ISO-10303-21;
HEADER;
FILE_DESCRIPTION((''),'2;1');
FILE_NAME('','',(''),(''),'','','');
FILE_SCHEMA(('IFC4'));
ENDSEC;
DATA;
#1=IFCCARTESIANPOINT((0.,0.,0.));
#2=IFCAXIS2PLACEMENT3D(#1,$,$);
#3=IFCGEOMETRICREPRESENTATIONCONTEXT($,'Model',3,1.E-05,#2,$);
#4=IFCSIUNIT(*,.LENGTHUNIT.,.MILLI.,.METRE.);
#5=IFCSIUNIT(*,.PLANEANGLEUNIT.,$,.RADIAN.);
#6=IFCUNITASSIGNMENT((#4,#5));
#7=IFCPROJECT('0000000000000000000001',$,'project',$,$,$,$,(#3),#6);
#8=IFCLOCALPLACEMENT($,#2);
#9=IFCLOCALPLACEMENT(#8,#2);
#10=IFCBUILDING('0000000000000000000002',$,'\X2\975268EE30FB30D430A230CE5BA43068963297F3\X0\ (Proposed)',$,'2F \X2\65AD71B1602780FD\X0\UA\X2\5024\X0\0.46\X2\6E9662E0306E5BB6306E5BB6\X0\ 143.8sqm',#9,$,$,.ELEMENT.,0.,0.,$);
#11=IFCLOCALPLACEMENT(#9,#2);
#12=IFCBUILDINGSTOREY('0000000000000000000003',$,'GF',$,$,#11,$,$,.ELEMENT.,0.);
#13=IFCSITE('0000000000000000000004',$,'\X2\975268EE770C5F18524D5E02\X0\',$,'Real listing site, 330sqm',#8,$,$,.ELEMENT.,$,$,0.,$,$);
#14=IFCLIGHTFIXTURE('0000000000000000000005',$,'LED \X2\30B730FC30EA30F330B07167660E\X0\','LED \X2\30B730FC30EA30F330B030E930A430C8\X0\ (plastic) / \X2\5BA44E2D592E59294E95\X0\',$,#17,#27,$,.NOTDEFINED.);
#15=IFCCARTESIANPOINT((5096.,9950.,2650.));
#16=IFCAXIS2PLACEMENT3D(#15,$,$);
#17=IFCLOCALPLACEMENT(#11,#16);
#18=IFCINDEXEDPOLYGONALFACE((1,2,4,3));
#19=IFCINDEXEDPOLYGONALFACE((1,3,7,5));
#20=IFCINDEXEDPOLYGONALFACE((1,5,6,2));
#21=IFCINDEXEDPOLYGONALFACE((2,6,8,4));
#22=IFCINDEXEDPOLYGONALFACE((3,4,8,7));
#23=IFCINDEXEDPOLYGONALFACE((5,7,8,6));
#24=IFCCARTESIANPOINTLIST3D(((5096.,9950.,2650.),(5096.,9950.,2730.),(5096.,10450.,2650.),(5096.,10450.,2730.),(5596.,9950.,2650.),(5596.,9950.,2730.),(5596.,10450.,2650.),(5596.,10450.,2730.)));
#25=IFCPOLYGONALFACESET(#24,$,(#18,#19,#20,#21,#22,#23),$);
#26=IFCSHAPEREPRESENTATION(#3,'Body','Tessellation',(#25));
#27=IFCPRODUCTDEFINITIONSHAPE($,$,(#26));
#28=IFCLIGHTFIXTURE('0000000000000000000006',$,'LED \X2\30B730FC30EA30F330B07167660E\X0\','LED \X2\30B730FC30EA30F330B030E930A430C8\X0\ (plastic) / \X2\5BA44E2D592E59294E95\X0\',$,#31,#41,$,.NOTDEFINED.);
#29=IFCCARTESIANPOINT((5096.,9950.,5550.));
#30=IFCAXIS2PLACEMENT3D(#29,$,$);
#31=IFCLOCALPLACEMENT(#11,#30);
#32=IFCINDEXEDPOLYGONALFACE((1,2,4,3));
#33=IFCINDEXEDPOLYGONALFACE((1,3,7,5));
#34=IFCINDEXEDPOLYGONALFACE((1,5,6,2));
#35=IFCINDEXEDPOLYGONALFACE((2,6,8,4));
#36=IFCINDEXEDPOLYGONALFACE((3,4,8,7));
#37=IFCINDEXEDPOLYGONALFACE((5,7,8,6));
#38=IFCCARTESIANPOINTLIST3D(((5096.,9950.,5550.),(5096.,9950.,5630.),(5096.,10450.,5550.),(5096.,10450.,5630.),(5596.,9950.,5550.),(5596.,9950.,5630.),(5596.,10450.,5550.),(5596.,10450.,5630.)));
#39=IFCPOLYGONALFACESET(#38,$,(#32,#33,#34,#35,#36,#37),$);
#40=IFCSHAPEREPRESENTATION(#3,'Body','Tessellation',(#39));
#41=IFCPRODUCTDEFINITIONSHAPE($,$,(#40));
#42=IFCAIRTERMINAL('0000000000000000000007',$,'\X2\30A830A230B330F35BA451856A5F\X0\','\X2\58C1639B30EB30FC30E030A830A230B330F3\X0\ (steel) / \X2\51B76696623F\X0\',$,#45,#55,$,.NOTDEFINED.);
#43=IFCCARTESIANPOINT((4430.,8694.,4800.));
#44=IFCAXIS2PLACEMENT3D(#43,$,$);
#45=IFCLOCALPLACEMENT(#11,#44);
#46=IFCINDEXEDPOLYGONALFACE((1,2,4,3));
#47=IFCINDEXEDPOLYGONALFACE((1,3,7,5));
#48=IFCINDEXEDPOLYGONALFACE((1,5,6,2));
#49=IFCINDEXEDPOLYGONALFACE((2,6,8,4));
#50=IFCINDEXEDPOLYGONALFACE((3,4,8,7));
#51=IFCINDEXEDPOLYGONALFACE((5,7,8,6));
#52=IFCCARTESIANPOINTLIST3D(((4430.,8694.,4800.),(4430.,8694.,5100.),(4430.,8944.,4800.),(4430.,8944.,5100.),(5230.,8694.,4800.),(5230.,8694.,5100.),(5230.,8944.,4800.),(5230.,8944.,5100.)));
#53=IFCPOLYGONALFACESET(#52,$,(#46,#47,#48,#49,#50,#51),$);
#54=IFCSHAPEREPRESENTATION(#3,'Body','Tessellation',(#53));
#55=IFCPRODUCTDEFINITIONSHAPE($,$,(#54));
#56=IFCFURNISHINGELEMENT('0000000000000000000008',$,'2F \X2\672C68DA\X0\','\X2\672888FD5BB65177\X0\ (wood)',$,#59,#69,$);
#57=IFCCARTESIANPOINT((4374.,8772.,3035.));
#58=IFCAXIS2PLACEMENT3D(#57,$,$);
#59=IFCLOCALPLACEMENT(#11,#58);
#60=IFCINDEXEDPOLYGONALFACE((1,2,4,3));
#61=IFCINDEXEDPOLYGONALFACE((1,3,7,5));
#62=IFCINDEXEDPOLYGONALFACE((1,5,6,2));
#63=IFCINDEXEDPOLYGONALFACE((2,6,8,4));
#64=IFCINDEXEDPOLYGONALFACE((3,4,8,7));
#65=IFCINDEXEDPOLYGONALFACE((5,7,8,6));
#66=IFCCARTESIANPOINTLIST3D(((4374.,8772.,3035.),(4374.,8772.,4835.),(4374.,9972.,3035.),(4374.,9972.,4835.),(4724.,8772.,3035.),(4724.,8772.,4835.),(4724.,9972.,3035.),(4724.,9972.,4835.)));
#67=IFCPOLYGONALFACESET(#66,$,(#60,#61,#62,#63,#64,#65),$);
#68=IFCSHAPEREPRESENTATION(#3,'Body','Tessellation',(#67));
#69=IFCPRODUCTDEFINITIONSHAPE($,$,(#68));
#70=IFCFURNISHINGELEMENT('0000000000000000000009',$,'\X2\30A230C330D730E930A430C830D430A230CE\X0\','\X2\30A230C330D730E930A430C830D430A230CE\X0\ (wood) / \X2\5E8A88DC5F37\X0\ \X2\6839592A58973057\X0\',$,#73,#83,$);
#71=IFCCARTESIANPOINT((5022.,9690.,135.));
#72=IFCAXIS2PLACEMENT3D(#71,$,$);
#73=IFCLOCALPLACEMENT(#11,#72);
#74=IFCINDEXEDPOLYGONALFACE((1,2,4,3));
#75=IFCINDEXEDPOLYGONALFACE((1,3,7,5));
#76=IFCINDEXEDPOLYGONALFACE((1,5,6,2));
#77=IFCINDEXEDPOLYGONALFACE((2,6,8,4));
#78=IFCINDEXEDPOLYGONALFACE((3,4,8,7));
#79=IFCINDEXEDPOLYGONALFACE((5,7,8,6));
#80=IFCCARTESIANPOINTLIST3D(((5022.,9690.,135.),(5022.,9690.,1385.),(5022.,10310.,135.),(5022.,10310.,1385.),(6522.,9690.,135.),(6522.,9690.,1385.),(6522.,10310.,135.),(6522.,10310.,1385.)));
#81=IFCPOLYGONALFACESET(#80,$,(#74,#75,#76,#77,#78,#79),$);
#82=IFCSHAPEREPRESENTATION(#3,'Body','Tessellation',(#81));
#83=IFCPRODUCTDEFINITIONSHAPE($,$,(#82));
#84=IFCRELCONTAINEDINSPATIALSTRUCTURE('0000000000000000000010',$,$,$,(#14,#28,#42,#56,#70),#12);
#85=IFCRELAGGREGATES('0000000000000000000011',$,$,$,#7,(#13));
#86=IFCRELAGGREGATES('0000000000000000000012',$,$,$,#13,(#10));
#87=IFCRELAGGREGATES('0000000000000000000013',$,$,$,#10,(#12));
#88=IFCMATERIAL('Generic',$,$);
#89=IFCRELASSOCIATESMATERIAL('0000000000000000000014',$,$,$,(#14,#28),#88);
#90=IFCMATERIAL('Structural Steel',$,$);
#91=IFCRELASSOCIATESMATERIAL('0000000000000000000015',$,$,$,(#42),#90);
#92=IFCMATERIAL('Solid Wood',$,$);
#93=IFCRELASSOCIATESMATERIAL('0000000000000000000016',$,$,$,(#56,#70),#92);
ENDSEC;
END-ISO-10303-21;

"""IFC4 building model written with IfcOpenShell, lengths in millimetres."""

from ifc_helpers import new_model, si_unit, frame, frame_2d, origin, place, context, project, spatial, rectangle, extrude, material, element, save


model = new_model("IFC4")

# Units and contexts
model_context = context("Model", 3, precision=1e-05, world=origin())
ifc_project = project(units=[si_unit("LENGTHUNIT", "METRE", prefix="MILLI"), si_unit("PLANEANGLEUNIT", "RADIAN")], contexts=[model_context])

# Site, building, storey
site_placement = place(None, origin())
site = spatial("IfcSite", under=ifc_project, at=site_placement, Name="青森県弘前市", ObjectType="Real listing site, 330sqm", CompositionType="ELEMENT", RefElevation=0.0)
building_placement = place(site_placement, origin())
building = spatial("IfcBuilding", under=site, at=building_placement, Name="青森・ピアノ室と防音 (Proposed)", ObjectType="2F 断熱性能UA値0.46準拠の家の家 143.8sqm", CompositionType="ELEMENT", ElevationOfRefHeight=0.0, ElevationOfTerrain=0.0)
storey_placement = place(building_placement, origin())
storey = spatial("IfcBuildingStorey", under=building, at=storey_placement, Name="GF", CompositionType="ELEMENT", Elevation=0.0)

# Shared definitions
ifc_material_1 = material(Name="Solid Wood")

# Shared definitions
ifc_material_2 = material(Name="Structural Steel")

# Shared definitions
ifc_material_3 = material(Name="Generic")

# Light fixtures
light_fixture_1_placement = place(storey_placement, frame((5096.0, 9950.0, 2650.0)))
element("IfcLightFixture", 1, at=light_fixture_1_placement, inside=storey, material=ifc_material_3, Name="LED シーリング照明", Description="LED シーリングライト (plastic) / 室中央天井", PredefinedType="NOTDEFINED", context=model_context, shape_type="SweptSolid", body=[
    extrude(rectangle(XDim=500.0, YDim=500.0, at=frame_2d((250.0, 250.0))), frame((5096.0, 9950.0, 2650.0)), (0.0, 0.0, 1.0), 80.0),
])
light_fixture_2_placement = place(storey_placement, frame((5096.0, 9950.0, 5550.0)))
element("IfcLightFixture", 2, at=light_fixture_2_placement, inside=storey, material=ifc_material_3, Name="LED シーリング照明", Description="LED シーリングライト (plastic) / 室中央天井", PredefinedType="NOTDEFINED", context=model_context, shape_type="SweptSolid", body=[
    extrude(rectangle(XDim=500.0, YDim=500.0, at=frame_2d((250.0, 250.0))), frame((5096.0, 9950.0, 5550.0)), (0.0, 0.0, 1.0), 80.0),
])

# Air terminal
air_terminal_placement = place(storey_placement, frame((4430.0, 8694.0, 4800.0)))
element("IfcAirTerminal", 3, at=air_terminal_placement, inside=storey, material=ifc_material_2, Name="エアコン室内機", Description="壁掛ルームエアコン (steel) / 冷暖房", PredefinedType="NOTDEFINED", context=model_context, shape_type="SweptSolid", body=[
    extrude(rectangle(XDim=800.0, YDim=250.0, at=frame_2d((400.0, 125.0))), frame((4430.0, 8694.0, 4800.0)), (0.0, 0.0, 1.0), 300.0),
])

# Furnishing elements
furnishing_1_placement = place(storey_placement, frame((4374.0, 8772.0, 3035.0)))
element("IfcFurnishingElement", 4, at=furnishing_1_placement, inside=storey, material=ifc_material_1, Name="2F 本棚", Description="木製家具 (wood)", context=model_context, shape_type="SweptSolid", body=[
    extrude(rectangle(XDim=350.0, YDim=1200.0, at=frame_2d((175.0, 600.0))), frame((4374.0, 8772.0, 3035.0)), (0.0, 0.0, 1.0), 1800.0),
])
furnishing_2_placement = place(storey_placement, frame((5022.0, 9690.0, 135.0)))
element("IfcFurnishingElement", 5, at=furnishing_2_placement, inside=storey, material=ifc_material_1, Name="アップライトピアノ", Description="アップライトピアノ (wood) / 床補強 根太増し", context=model_context, shape_type="SweptSolid", body=[
    extrude(rectangle(XDim=1500.0, YDim=620.0, at=frame_2d((750.0, 310.0))), frame((5022.0, 9690.0, 135.0)), (0.0, 0.0, 1.0), 1250.0),
])

save(model, "model.ifc")
